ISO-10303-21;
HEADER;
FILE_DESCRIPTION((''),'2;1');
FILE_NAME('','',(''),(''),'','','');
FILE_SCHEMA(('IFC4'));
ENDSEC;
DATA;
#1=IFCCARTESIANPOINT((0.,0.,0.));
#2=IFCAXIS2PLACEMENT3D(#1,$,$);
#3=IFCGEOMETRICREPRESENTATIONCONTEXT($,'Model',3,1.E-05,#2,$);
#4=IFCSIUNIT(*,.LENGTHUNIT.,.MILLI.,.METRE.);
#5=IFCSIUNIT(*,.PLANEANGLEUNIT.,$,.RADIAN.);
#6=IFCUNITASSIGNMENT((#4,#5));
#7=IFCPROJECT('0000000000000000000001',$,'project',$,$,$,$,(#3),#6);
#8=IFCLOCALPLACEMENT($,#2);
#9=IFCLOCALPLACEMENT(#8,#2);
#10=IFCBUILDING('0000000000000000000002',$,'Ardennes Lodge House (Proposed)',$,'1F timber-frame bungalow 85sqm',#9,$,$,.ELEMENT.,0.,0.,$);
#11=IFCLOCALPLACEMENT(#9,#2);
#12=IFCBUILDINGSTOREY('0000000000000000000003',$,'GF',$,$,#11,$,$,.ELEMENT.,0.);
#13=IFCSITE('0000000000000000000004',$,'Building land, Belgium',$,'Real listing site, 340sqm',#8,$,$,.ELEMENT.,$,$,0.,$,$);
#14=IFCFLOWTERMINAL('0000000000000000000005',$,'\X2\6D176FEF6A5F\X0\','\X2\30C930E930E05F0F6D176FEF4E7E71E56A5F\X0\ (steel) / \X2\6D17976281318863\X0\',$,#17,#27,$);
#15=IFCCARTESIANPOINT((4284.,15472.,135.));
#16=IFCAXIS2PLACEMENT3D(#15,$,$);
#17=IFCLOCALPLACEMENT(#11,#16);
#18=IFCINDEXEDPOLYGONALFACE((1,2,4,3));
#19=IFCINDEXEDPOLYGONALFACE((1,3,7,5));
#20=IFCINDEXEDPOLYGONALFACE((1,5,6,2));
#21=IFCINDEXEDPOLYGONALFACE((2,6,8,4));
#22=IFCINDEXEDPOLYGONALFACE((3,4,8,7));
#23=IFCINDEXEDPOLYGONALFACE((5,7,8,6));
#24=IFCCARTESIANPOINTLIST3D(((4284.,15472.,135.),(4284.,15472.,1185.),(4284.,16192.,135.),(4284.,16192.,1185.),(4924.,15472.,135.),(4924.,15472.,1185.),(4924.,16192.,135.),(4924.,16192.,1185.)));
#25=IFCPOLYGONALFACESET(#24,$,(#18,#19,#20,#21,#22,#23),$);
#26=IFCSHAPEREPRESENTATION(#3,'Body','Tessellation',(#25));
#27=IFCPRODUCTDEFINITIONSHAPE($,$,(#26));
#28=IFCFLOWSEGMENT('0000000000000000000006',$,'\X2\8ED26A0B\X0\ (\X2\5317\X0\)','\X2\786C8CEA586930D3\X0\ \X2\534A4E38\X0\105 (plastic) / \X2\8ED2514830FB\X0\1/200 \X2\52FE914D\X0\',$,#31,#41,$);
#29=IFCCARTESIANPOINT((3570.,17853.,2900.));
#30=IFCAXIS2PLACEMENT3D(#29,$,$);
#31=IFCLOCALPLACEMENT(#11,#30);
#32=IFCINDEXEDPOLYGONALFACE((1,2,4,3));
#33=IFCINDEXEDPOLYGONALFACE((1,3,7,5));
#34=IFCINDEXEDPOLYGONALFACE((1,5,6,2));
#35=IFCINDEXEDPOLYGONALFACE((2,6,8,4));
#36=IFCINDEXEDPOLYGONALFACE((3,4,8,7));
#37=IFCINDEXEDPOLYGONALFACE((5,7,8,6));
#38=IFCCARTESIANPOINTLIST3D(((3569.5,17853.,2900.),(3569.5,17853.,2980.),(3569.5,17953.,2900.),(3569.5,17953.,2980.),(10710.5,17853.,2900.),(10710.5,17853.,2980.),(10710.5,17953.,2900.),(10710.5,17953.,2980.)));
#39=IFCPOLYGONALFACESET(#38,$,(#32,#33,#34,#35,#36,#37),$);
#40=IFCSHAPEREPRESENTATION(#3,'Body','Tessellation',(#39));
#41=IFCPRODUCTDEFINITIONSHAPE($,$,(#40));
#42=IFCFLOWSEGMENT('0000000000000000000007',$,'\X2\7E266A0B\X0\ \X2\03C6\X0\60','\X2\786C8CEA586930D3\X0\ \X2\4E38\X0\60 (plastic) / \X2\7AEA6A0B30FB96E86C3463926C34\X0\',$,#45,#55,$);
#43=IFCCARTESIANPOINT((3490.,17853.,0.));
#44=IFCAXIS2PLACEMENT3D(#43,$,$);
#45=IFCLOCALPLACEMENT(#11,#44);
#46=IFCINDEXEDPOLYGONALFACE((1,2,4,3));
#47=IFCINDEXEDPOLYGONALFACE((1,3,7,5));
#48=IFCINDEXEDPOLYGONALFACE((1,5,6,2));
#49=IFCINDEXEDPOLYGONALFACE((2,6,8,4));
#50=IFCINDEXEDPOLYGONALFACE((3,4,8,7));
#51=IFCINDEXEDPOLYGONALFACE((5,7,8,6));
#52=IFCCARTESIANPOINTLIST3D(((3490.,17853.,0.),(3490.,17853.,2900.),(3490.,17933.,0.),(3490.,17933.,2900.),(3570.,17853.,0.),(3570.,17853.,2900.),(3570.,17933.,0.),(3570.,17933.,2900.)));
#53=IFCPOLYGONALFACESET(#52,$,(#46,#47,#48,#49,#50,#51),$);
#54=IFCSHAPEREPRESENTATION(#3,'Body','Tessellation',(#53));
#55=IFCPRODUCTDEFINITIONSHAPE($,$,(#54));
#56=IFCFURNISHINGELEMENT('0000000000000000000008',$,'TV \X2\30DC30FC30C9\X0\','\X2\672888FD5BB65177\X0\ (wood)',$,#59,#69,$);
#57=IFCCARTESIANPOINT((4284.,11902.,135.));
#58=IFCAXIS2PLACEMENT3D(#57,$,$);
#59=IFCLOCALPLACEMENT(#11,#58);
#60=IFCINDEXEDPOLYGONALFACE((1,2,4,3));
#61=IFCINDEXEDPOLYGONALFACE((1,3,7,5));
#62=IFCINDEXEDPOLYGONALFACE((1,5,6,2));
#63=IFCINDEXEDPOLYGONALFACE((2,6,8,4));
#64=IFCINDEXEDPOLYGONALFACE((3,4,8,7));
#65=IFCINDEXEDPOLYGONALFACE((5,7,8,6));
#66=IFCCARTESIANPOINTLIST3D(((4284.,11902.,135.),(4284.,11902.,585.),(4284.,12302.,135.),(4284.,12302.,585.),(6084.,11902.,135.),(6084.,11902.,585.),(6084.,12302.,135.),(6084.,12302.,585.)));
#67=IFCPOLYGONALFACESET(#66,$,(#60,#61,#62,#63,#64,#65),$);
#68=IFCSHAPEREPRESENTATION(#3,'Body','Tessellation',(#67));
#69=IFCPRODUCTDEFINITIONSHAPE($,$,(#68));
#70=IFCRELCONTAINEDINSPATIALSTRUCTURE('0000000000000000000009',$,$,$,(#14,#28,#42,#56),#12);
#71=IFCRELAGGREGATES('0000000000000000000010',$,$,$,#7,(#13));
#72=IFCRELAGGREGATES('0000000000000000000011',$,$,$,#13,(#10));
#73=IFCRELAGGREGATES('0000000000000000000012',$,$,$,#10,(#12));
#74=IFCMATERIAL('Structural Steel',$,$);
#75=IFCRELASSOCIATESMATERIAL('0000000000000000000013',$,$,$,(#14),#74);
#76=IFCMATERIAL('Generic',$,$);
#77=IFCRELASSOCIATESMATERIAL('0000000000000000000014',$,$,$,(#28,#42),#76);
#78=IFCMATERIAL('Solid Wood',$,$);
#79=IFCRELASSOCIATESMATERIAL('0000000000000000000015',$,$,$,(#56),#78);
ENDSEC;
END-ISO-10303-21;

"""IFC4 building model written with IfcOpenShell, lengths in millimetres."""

from ifc_helpers import new_model, si_unit, frame, frame_2d, origin, place, context, project, spatial, rectangle, extrude, material, element, save


model = new_model("IFC4")

# Units and contexts
model_context = context("Model", 3, precision=1e-05, world=origin())
ifc_project = project(units=[si_unit("LENGTHUNIT", "METRE", prefix="MILLI"), si_unit("PLANEANGLEUNIT", "RADIAN")], contexts=[model_context])

# Site, building, storey
site_placement = place(None, origin())
site = spatial("IfcSite", under=ifc_project, at=site_placement, Name="Building land, Belgium", ObjectType="Real listing site, 340sqm", CompositionType="ELEMENT", RefElevation=0.0)
building_placement = place(site_placement, origin())
building = spatial("IfcBuilding", under=site, at=building_placement, Name="Ardennes Lodge House (Proposed)", ObjectType="1F timber-frame bungalow 85sqm", CompositionType="ELEMENT", ElevationOfRefHeight=0.0, ElevationOfTerrain=0.0)
storey_placement = place(building_placement, origin())
storey = spatial("IfcBuildingStorey", under=building, at=storey_placement, Name="GF", CompositionType="ELEMENT", Elevation=0.0)

# Shared definitions
ifc_material_1 = material(Name="Solid Wood")

# Shared definitions
ifc_material_2 = material(Name="Structural Steel")

# Shared definitions
ifc_material_3 = material(Name="Generic")

# Flow terminal
flow_terminal_placement = place(storey_placement, frame((4284.0, 15472.0, 135.0)))
element("IfcFlowTerminal", 1, at=flow_terminal_placement, inside=storey, material=ifc_material_2, Name="洗濯機", Description="ドラム式洗濯乾燥機 (steel) / 洗面脱衣", context=model_context, shape_type="SweptSolid", body=[
    extrude(rectangle(XDim=640.0, YDim=720.0, at=frame_2d((320.0, 360.0))), frame((4284.0, 15472.0, 135.0)), (0.0, 0.0, 1.0), 1050.0),
])

# Flow segments
flow_segment_1_placement = place(storey_placement, frame((3570.0, 17853.0, 2900.0)))
element("IfcFlowSegment", 2, at=flow_segment_1_placement, inside=storey, material=ifc_material_3, Name="軒樋 (北)", Description="硬質塩ビ 半丸105 (plastic) / 軒先・1/200 勾配", context=model_context, shape_type="SweptSolid", body=[
    extrude(rectangle(XDim=7141.0, YDim=100.0, at=frame_2d((3570.0, 50.0))), frame((3570.0, 17853.0, 2900.0)), (0.0, 0.0, 1.0), 80.0),
])
flow_segment_2_placement = place(storey_placement, frame((3490.0, 17853.0, 0.0)))
element("IfcFlowSegment", 3, at=flow_segment_2_placement, inside=storey, material=ifc_material_3, Name="縦樋 φ60", Description="硬質塩ビ 丸60 (plastic) / 竪樋・雨水排水", context=model_context, shape_type="SweptSolid", body=[
    extrude(rectangle(XDim=80.0, YDim=80.0, at=frame_2d((40.0, 40.0))), frame((3490.0, 17853.0, 0.0)), (0.0, 0.0, 1.0), 2900.0),
])

# Furnishing element
furnishing_placement = place(storey_placement, frame((4284.0, 11902.0, 135.0)))
element("IfcFurnishingElement", 4, at=furnishing_placement, inside=storey, material=ifc_material_1, Name="TV ボード", Description="木製家具 (wood)", context=model_context, shape_type="SweptSolid", body=[
    extrude(rectangle(XDim=1800.0, YDim=400.0, at=frame_2d((900.0, 200.0))), frame((4284.0, 11902.0, 135.0)), (0.0, 0.0, 1.0), 450.0),
])

save(model, "model.ifc")
